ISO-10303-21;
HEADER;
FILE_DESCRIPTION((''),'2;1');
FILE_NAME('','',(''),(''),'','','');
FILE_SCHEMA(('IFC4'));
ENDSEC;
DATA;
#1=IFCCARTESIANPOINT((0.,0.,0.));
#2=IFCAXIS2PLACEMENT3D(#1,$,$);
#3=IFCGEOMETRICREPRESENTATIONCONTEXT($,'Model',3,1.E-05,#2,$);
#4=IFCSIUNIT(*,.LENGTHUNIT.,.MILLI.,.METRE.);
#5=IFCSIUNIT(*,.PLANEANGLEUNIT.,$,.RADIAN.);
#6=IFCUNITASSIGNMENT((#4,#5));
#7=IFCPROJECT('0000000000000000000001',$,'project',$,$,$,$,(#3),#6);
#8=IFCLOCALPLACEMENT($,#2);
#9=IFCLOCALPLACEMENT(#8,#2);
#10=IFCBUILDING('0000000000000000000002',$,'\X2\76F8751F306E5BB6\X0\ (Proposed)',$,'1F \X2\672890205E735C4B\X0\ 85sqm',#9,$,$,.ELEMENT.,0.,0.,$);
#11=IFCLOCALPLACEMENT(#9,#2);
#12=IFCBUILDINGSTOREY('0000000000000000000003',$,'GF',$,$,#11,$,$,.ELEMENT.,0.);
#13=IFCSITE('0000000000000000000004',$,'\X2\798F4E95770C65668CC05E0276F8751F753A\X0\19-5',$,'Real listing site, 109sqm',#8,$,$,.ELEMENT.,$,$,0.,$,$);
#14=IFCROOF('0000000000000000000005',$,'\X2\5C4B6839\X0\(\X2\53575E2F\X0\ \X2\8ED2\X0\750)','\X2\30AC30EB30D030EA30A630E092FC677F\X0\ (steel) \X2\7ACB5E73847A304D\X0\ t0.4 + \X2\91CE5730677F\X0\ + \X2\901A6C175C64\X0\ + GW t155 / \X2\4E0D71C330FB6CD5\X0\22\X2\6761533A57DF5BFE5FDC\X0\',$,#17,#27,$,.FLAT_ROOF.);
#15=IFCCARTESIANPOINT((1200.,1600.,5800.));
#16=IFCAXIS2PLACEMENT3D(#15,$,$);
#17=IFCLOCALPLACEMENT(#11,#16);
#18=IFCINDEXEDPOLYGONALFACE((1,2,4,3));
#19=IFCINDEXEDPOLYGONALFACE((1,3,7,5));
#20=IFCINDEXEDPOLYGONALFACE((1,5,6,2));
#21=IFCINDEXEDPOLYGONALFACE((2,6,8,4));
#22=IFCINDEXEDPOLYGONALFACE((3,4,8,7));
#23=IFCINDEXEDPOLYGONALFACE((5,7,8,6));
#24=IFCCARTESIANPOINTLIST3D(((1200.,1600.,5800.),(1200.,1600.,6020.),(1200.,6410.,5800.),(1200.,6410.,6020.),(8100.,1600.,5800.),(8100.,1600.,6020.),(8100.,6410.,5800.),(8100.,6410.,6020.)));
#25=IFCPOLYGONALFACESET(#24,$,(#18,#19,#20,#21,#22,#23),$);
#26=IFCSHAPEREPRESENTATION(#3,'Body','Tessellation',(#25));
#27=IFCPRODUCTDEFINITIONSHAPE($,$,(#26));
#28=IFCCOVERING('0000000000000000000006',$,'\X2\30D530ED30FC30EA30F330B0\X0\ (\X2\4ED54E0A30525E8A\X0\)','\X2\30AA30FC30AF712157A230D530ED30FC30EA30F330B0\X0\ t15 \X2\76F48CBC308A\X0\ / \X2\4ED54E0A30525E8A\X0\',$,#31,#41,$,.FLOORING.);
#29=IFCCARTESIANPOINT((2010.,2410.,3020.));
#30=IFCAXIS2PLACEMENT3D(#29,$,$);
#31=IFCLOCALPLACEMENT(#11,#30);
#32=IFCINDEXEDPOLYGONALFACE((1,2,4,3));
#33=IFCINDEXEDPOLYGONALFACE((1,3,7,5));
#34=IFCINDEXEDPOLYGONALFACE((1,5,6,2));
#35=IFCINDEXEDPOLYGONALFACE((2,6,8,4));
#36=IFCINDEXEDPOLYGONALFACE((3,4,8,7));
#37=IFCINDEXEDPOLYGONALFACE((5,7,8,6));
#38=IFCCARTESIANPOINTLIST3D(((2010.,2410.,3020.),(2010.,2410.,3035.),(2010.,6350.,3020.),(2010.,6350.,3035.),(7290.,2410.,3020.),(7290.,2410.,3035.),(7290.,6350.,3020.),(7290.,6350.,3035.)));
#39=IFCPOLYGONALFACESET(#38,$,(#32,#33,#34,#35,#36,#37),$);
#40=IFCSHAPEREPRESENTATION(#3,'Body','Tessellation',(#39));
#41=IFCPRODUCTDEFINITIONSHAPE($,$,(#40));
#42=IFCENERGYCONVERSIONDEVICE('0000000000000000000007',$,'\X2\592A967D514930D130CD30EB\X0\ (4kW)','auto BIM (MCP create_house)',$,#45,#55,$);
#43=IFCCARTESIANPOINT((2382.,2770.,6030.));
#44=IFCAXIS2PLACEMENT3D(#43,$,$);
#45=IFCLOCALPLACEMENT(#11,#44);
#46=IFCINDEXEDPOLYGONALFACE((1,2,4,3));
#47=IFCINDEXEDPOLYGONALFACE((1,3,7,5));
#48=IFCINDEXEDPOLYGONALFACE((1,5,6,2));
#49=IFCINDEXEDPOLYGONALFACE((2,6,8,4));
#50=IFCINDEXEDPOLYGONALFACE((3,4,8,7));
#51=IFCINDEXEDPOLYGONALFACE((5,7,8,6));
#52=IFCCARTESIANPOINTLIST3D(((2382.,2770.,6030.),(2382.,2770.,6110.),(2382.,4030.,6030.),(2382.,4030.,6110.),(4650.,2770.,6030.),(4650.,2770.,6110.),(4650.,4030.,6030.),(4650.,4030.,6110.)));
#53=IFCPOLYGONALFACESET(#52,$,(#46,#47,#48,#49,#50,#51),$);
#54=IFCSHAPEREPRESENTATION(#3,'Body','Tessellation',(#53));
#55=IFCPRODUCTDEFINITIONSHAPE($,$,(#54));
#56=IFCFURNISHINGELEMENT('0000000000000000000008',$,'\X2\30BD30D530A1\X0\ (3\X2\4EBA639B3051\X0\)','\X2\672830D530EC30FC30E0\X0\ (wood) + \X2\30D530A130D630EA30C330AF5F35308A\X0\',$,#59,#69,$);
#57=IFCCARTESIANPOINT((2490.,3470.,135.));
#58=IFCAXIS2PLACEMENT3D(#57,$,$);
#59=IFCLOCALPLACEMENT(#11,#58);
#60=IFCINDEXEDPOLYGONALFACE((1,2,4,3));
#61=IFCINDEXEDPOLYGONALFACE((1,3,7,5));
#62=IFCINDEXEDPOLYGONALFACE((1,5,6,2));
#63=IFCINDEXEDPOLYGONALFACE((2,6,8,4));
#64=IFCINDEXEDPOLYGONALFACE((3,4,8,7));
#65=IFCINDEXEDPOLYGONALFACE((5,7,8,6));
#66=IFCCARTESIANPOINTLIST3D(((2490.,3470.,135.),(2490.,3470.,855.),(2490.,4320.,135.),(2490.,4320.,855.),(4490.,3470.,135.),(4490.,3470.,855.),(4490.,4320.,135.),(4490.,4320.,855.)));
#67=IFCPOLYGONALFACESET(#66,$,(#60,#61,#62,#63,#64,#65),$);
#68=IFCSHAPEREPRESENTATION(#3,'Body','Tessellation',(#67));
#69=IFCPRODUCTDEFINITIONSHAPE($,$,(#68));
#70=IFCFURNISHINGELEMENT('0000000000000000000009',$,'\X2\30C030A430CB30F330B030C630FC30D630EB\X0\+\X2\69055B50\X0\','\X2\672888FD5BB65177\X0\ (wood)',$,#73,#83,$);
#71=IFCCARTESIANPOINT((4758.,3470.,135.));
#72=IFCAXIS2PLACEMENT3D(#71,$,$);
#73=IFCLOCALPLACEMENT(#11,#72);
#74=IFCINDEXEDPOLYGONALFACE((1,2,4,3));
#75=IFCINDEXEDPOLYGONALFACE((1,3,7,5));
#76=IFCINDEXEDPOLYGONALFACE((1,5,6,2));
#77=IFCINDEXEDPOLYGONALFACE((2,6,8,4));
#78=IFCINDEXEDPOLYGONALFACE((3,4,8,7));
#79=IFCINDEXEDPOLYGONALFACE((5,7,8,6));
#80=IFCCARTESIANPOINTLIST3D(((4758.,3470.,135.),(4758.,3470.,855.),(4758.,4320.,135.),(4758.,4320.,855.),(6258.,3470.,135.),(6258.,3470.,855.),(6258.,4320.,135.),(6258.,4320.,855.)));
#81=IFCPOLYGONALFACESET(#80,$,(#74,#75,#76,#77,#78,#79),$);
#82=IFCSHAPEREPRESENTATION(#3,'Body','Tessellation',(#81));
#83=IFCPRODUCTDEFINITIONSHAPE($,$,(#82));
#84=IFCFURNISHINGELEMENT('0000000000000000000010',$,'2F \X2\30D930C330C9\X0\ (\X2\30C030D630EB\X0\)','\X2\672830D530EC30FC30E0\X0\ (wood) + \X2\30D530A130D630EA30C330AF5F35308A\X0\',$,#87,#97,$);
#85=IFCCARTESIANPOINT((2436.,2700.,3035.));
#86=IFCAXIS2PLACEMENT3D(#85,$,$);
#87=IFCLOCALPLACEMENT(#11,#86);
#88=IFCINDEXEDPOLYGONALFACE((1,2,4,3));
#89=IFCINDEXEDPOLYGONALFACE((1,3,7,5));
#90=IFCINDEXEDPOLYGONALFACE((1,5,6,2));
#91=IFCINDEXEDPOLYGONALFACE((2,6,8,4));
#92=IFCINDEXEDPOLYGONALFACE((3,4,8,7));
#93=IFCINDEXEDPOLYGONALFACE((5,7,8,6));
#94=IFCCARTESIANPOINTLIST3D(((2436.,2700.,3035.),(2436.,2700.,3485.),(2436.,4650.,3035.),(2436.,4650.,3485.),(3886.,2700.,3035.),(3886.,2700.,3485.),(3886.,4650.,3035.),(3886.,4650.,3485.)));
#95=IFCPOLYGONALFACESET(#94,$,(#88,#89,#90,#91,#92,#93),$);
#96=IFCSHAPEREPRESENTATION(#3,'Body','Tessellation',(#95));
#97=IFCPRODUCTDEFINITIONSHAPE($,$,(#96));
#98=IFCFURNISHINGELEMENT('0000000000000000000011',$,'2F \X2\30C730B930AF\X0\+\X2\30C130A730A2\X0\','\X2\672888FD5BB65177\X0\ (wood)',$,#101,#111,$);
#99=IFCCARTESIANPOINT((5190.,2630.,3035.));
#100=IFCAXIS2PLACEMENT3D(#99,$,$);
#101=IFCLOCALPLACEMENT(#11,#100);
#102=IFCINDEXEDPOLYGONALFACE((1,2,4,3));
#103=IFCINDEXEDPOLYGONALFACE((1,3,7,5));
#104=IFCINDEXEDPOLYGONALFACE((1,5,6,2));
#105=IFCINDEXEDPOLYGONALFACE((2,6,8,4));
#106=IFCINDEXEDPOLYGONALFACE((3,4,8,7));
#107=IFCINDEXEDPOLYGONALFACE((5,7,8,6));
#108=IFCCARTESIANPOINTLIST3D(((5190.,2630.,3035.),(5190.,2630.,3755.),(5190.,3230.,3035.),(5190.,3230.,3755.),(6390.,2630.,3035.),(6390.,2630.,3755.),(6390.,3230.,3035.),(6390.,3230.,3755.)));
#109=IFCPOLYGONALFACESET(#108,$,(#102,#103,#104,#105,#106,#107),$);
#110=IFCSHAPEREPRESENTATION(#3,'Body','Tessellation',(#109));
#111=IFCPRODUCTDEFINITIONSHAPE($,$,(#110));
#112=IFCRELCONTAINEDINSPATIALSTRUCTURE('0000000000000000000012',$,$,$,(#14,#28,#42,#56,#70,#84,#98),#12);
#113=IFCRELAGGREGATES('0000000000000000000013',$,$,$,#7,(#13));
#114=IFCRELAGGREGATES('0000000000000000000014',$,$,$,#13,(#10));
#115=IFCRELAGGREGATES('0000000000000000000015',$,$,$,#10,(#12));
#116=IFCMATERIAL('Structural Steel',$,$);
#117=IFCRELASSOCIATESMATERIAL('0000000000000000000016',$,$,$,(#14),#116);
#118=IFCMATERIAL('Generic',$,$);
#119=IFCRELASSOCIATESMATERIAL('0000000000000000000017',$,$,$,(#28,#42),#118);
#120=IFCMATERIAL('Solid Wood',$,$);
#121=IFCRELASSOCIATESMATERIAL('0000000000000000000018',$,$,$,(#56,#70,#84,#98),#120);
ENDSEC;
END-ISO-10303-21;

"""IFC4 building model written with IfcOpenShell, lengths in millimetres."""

from ifc_helpers import new_model, si_unit, frame, frame_2d, origin, place, context, project, spatial, rectangle, extrude, material, element, save


model = new_model("IFC4")

# Units and contexts
model_context = context("Model", 3, precision=1e-05, world=origin())
ifc_project = project(units=[si_unit("LENGTHUNIT", "METRE", prefix="MILLI"), si_unit("PLANEANGLEUNIT", "RADIAN")], contexts=[model_context])

# Site, building, storey
site_placement = place(None, origin())
site = spatial("IfcSite", under=ifc_project, at=site_placement, Name="福井県敦賀市相生町19-5", ObjectType="Real listing site, 109sqm", CompositionType="ELEMENT", RefElevation=0.0)
building_placement = place(site_placement, origin())
building = spatial("IfcBuilding", under=site, at=building_placement, Name="相生の家 (Proposed)", ObjectType="1F 木造平屋 85sqm", CompositionType="ELEMENT", ElevationOfRefHeight=0.0, ElevationOfTerrain=0.0)
storey_placement = place(building_placement, origin())
storey = spatial("IfcBuildingStorey", under=building, at=storey_placement, Name="GF", CompositionType="ELEMENT", Elevation=0.0)

# Shared definitions
ifc_material_1 = material(Name="Solid Wood")

# Shared definitions
ifc_material_2 = material(Name="Generic")

# Roof
ifc_material_3 = material(Name="Structural Steel")
for number, where, name in (
    (1, (1200.0, 1600.0, 5800.0), "屋根(南帯 軒750)"),
):
    element("IfcRoof", number, at=place(storey_placement, frame(where)), inside=storey, material=ifc_material_3, Name=name, Description="ガルバリウム鋼板 (steel) 立平葺き t0.4 + 野地板 + 通気層 + GW t155 / 不燃・法22条区域対応", PredefinedType="FLAT_ROOF", context=model_context, shape_type="SweptSolid", body=[
        extrude(rectangle(XDim=6900.0, YDim=4810.0, at=frame_2d((3450.0, 2405.0))), frame((1200.0, 1600.0, 5800.0)), (0.0, 0.0, 1.0), 220.0),
    ])

# Covering
covering_placement = place(storey_placement, frame((2010.0, 2410.0, 3020.0)))
element("IfcCovering", 2, at=covering_placement, inside=storey, material=ifc_material_2, Name="フローリング (仕上げ床)", Description="オーク無垢フローリング t15 直貼り / 仕上げ床", PredefinedType="FLOORING", context=model_context, shape_type="SweptSolid", body=[
    extrude(rectangle(XDim=5280.0, YDim=3940.0, at=frame_2d((2640.0, 1970.0))), frame((2010.0, 2410.0, 3020.0)), (0.0, 0.0, 1.0), 15.0),
])

# Energy conversion device
energy_conversion_device_placement = place(storey_placement, frame((2382.0, 2770.0, 6030.0)))
element("IfcEnergyConversionDevice", 3, at=energy_conversion_device_placement, inside=storey, material=ifc_material_2, Name="太陽光パネル (4kW)", Description="auto BIM (MCP create_house)", context=model_context, shape_type="SweptSolid", body=[
    extrude(rectangle(XDim=2268.0, YDim=1260.0, at=frame_2d((1134.0, 630.0))), frame((2382.0, 2770.0, 6030.0)), (0.0, 0.0, 1.0), 80.0),
])

# Furnishing elements
furnishing_1_placement = place(storey_placement, frame((2490.0, 3470.0, 135.0)))
element("IfcFurnishingElement", 4, at=furnishing_1_placement, inside=storey, material=ifc_material_1, Name="ソファ (3人掛け)", Description="木フレーム (wood) + ファブリック張り", context=model_context, shape_type="SweptSolid", body=[
    extrude(rectangle(XDim=2000.0, YDim=850.0, at=frame_2d((1000.0, 425.0))), frame((2490.0, 3470.0, 135.0)), (0.0, 0.0, 1.0), 720.0),
])
furnishing_2_placement = place(storey_placement, frame((4758.0, 3470.0, 135.0)))
element("IfcFurnishingElement", 5, at=furnishing_2_placement, inside=storey, material=ifc_material_1, Name="ダイニングテーブル+椅子", Description="木製家具 (wood)", context=model_context, shape_type="SweptSolid", body=[
    extrude(rectangle(XDim=1500.0, YDim=850.0, at=frame_2d((750.0, 425.0))), frame((4758.0, 3470.0, 135.0)), (0.0, 0.0, 1.0), 720.0),
])
furnishing_3_placement = place(storey_placement, frame((2436.0, 2700.0, 3035.0)))
element("IfcFurnishingElement", 6, at=furnishing_3_placement, inside=storey, material=ifc_material_1, Name="2F ベッド (ダブル)", Description="木フレーム (wood) + ファブリック張り", context=model_context, shape_type="SweptSolid", body=[
    extrude(rectangle(XDim=1450.0, YDim=1950.0, at=frame_2d((725.0, 975.0))), frame((2436.0, 2700.0, 3035.0)), (0.0, 0.0, 1.0), 450.0),
])
furnishing_4_placement = place(storey_placement, frame((5190.0, 2630.0, 3035.0)))
element("IfcFurnishingElement", 7, at=furnishing_4_placement, inside=storey, material=ifc_material_1, Name="2F デスク+チェア", Description="木製家具 (wood)", context=model_context, shape_type="SweptSolid", body=[
    extrude(rectangle(XDim=1200.0, YDim=600.0, at=frame_2d((600.0, 300.0))), frame((5190.0, 2630.0, 3035.0)), (0.0, 0.0, 1.0), 720.0),
])

save(model, "model.ifc")
